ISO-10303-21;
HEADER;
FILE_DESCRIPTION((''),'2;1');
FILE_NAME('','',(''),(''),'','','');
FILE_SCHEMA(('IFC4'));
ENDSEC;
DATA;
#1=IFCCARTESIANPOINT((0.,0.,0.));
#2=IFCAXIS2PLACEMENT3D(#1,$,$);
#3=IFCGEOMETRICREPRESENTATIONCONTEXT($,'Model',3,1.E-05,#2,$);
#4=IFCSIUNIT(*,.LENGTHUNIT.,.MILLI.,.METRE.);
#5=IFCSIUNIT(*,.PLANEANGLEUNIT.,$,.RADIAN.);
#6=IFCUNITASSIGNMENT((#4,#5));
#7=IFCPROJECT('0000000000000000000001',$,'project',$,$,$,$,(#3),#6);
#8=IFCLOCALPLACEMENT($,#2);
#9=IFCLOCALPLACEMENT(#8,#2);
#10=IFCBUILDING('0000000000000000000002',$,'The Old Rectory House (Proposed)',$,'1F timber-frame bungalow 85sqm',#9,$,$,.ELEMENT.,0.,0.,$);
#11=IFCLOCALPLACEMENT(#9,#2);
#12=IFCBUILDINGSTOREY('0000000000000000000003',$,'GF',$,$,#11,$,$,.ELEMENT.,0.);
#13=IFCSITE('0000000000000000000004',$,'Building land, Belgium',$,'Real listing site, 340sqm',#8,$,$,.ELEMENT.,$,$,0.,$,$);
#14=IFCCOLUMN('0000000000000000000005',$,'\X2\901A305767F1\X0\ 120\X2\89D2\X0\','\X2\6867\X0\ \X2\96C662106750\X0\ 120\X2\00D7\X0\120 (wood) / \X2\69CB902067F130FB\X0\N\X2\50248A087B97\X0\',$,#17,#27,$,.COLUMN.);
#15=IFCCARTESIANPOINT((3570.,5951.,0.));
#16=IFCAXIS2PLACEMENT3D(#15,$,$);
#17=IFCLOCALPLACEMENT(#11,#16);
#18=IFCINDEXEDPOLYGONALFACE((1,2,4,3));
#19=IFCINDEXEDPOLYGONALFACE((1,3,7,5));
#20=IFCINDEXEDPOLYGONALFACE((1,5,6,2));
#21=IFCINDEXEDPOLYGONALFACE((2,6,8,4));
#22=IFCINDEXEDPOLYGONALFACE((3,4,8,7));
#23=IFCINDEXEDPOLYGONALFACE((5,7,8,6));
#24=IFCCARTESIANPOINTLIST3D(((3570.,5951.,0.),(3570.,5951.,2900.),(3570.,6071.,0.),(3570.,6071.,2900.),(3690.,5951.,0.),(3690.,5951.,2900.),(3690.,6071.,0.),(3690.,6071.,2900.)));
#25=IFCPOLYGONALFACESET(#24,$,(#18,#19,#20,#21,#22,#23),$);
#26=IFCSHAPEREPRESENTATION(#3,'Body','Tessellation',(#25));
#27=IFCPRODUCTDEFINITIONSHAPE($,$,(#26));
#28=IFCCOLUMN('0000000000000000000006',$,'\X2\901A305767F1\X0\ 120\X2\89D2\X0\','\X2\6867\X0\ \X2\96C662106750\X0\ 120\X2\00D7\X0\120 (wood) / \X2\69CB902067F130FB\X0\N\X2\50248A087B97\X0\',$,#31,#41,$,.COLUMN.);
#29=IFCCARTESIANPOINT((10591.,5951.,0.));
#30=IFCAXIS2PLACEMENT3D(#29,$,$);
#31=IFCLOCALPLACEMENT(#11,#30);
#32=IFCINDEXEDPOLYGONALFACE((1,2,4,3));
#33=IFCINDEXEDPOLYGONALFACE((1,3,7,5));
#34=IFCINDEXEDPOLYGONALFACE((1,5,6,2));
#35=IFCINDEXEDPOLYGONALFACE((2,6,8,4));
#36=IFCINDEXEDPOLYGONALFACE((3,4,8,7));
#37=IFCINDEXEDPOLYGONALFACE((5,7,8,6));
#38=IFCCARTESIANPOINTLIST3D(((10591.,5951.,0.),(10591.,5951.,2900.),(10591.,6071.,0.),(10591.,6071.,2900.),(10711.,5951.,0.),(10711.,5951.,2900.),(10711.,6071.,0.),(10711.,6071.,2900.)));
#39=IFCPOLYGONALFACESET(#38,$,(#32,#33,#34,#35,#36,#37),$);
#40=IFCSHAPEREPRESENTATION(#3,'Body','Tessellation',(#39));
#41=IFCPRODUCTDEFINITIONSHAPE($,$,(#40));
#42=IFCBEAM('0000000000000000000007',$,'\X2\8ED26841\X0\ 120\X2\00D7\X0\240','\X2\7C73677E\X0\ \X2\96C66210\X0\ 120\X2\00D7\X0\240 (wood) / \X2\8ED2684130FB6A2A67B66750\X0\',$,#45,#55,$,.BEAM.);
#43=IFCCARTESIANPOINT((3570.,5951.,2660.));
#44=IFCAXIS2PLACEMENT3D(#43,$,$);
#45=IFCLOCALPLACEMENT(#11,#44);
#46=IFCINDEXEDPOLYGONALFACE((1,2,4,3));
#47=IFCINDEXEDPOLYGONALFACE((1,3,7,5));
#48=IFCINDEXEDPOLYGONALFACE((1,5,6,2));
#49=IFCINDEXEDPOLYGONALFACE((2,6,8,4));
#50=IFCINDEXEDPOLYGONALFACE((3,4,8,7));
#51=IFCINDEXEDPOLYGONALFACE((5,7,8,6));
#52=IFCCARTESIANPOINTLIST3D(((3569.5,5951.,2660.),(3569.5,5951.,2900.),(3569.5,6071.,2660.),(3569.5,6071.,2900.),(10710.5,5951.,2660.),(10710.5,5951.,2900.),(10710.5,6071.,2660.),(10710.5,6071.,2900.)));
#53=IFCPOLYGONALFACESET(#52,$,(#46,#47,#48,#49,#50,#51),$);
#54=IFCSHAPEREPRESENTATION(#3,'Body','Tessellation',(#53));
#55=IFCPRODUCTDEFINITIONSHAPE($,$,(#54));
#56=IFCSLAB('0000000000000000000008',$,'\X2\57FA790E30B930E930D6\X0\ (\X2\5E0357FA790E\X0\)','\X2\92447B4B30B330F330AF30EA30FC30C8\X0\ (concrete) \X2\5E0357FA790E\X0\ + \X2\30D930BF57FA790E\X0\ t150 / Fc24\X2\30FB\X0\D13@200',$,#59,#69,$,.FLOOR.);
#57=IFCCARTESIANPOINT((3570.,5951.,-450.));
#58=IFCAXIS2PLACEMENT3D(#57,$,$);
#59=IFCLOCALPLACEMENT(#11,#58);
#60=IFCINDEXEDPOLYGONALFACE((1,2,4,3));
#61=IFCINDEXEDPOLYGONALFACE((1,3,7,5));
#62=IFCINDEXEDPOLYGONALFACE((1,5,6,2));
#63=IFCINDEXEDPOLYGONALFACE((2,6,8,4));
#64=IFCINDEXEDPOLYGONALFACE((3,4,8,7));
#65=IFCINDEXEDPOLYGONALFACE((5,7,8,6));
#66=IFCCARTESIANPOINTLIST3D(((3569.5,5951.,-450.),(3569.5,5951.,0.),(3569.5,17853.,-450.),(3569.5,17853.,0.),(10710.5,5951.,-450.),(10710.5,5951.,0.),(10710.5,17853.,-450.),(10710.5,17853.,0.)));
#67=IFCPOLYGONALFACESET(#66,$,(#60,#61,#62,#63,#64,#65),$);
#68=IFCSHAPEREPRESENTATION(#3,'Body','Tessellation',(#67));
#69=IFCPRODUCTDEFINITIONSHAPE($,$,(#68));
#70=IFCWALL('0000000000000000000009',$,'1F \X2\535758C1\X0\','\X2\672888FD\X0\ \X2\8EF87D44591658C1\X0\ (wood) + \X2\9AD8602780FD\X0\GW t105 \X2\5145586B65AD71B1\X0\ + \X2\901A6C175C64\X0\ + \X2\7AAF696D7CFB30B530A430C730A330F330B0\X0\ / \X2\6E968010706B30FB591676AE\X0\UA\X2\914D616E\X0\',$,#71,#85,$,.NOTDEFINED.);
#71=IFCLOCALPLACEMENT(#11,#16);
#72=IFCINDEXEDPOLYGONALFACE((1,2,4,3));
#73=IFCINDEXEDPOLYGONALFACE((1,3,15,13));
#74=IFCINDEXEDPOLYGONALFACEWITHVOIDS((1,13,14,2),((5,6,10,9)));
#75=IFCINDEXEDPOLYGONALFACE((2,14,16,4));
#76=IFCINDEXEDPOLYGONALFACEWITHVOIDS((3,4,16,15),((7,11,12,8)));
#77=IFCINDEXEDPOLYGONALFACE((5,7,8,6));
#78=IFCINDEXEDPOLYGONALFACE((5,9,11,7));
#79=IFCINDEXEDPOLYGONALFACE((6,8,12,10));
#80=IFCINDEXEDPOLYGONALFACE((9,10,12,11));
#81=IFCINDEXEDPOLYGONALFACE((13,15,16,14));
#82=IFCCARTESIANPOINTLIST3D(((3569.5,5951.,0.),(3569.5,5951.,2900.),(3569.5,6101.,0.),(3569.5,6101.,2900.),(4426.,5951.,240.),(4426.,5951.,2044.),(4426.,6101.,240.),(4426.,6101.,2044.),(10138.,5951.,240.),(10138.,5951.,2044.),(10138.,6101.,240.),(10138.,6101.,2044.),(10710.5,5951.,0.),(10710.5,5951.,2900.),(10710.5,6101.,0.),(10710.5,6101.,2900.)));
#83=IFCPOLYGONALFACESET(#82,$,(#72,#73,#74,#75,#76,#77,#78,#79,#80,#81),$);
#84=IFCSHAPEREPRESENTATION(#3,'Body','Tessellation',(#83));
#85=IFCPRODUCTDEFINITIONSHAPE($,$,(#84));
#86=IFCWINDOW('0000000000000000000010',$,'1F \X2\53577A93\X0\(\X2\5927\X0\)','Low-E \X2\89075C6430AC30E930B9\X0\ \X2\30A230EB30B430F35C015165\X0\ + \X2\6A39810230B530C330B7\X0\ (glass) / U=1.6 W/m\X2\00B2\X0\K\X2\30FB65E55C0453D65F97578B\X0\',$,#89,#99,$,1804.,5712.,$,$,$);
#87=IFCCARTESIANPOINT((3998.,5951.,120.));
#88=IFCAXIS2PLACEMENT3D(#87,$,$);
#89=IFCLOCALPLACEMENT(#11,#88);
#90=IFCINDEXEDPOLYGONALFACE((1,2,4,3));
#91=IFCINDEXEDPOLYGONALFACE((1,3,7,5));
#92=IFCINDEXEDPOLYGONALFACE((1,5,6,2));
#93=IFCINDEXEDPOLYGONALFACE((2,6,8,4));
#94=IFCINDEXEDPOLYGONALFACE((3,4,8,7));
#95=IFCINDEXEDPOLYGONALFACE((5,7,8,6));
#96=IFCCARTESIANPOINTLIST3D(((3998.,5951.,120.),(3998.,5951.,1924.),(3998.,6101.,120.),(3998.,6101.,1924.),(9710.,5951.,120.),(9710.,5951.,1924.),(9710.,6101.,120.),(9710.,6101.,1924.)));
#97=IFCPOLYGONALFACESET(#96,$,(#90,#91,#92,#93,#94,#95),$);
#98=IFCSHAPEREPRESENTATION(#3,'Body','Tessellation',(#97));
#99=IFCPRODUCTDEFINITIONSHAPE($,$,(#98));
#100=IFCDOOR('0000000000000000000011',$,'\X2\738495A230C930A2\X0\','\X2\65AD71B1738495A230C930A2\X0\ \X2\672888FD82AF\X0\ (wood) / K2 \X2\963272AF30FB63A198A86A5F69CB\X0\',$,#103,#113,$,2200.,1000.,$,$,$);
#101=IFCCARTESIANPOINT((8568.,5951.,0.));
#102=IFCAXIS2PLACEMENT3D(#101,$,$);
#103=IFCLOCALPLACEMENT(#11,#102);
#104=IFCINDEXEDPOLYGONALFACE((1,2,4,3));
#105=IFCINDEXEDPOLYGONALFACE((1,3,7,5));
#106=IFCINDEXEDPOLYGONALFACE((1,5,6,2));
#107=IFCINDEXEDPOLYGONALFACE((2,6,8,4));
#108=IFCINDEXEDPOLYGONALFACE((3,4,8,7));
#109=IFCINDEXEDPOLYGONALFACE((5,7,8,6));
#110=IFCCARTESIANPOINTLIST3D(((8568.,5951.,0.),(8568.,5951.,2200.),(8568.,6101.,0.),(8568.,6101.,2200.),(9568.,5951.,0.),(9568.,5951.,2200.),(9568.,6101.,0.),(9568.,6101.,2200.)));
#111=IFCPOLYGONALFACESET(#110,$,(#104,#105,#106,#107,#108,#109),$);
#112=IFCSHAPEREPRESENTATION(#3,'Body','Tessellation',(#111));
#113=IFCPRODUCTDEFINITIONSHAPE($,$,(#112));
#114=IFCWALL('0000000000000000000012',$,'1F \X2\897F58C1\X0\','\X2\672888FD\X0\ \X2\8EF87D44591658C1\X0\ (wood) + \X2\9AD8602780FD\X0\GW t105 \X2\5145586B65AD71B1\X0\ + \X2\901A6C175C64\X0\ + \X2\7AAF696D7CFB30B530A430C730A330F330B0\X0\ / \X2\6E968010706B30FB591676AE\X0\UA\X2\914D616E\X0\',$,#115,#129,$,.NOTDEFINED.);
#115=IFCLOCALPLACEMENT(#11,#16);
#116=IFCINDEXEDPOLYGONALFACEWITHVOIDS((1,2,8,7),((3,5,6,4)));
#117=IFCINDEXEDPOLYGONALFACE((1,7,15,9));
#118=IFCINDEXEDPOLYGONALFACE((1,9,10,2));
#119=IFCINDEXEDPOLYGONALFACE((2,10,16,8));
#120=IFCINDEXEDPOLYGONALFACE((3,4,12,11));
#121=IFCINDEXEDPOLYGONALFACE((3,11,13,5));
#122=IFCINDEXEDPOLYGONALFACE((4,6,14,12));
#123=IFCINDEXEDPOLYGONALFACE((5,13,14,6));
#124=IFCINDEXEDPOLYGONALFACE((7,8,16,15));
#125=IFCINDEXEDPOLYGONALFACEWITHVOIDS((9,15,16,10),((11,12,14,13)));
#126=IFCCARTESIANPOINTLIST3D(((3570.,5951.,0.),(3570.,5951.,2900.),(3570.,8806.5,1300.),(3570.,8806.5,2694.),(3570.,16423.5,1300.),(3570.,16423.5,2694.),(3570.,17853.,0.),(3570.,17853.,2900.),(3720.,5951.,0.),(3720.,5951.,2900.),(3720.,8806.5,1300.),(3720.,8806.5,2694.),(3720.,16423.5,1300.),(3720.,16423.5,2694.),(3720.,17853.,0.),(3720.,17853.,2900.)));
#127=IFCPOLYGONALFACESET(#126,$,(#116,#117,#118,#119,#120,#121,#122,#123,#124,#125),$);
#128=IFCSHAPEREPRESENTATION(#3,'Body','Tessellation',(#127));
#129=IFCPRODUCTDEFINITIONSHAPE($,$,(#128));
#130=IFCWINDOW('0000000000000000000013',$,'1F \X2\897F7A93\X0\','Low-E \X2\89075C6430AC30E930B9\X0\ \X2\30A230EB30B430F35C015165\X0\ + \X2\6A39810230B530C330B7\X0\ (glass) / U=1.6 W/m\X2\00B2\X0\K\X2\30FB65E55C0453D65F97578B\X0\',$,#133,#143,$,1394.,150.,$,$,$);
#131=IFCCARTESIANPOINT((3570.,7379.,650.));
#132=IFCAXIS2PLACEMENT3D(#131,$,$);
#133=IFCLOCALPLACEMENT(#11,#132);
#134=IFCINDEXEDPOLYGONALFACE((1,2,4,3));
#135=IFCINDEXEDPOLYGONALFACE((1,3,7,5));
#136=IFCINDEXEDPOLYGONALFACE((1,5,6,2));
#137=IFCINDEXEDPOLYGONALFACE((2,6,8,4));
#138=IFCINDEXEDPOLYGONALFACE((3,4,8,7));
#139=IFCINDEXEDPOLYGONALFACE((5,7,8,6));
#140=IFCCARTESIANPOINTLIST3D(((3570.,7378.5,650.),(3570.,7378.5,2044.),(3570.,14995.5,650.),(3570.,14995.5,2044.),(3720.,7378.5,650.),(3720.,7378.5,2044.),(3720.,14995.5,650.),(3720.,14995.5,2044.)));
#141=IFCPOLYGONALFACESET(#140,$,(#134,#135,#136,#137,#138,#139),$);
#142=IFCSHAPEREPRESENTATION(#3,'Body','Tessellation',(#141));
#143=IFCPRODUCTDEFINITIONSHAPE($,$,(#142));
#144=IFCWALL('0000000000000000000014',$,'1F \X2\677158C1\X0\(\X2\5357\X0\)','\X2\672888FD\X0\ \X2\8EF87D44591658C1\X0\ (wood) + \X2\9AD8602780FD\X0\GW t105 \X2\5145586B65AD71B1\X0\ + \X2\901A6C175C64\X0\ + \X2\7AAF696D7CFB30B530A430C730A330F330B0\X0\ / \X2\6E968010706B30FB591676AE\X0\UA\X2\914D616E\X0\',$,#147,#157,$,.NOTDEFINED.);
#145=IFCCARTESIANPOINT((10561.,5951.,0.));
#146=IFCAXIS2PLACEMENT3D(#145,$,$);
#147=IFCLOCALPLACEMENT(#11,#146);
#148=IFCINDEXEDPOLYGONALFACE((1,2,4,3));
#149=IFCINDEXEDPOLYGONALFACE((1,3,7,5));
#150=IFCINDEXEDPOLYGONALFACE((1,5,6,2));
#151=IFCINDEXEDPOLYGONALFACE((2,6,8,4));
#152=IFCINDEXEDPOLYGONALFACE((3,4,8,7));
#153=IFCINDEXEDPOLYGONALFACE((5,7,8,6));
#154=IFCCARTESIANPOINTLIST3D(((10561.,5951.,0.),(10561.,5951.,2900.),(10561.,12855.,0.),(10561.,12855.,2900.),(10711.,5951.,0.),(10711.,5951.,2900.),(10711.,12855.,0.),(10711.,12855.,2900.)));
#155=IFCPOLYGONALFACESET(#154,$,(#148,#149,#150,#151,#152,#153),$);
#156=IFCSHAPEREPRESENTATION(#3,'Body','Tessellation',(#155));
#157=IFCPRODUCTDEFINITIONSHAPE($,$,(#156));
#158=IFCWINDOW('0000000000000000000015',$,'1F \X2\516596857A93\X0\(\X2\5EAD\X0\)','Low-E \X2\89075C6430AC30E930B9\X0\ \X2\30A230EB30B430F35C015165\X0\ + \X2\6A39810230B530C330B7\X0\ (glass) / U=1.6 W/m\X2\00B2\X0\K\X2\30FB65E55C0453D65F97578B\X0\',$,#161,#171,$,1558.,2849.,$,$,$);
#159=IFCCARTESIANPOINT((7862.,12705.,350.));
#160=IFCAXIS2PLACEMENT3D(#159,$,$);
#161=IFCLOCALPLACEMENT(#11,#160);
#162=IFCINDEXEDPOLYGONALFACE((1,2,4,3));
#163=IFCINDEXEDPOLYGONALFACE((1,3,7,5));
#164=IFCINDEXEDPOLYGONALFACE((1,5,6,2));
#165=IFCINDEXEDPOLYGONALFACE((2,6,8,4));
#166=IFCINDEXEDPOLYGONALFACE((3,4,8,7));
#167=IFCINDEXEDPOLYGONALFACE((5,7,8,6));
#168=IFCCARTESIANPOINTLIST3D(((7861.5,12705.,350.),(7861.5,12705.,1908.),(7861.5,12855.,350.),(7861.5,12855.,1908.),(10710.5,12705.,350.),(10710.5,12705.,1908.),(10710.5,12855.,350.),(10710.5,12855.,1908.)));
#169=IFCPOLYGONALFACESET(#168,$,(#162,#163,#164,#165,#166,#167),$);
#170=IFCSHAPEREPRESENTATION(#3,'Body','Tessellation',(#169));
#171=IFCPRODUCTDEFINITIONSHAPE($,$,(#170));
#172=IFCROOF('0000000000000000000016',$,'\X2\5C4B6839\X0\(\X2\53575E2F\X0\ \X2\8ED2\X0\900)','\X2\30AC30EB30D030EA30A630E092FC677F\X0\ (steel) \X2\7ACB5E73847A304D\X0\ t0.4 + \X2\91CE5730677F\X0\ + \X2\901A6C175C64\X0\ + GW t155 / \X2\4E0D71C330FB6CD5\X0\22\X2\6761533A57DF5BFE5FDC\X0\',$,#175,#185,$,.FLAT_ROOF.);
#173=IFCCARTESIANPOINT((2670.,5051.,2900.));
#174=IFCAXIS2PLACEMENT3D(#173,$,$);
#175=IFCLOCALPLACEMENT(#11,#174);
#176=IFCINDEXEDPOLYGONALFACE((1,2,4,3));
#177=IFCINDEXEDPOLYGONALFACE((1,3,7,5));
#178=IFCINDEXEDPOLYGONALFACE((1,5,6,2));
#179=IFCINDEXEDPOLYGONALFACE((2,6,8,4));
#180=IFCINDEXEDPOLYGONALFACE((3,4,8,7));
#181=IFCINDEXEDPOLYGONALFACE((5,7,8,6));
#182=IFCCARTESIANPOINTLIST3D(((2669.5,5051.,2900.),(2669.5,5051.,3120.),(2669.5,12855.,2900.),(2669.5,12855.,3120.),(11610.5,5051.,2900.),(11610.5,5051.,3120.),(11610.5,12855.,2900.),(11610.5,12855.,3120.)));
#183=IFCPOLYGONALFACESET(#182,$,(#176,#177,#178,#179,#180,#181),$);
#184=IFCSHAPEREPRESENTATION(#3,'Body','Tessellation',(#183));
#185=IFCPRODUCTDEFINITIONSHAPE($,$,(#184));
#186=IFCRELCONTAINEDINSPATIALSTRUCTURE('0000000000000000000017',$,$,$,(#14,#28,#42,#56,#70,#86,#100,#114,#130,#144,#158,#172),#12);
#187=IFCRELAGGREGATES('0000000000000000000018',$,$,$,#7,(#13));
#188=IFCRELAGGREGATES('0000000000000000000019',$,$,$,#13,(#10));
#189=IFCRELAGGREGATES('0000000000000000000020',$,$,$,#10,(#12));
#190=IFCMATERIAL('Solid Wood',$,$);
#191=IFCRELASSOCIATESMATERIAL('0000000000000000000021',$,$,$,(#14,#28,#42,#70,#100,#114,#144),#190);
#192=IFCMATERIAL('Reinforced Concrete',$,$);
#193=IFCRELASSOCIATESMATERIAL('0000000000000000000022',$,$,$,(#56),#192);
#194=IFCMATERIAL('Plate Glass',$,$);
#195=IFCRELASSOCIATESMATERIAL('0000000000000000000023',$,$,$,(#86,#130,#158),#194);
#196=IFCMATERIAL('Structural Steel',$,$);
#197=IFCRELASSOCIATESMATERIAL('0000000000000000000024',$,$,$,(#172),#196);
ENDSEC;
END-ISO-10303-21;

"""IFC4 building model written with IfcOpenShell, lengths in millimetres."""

from ifc_helpers import new_model, si_unit, frame, frame_2d, origin, place, context, project, spatial, rectangle, extrude, material, element, fill, save


model = new_model("IFC4")

# Units and contexts
model_context = context("Model", 3, precision=1e-05, world=origin())
ifc_project = project(units=[si_unit("LENGTHUNIT", "METRE", prefix="MILLI"), si_unit("PLANEANGLEUNIT", "RADIAN")], contexts=[model_context])

# Site, building, storey
site_placement = place(None, origin())
site = spatial("IfcSite", under=ifc_project, at=site_placement, Name="Building land, Belgium", ObjectType="Real listing site, 340sqm", CompositionType="ELEMENT", RefElevation=0.0)
building_placement = place(site_placement, origin())
building = spatial("IfcBuilding", under=site, at=building_placement, Name="The Old Rectory House (Proposed)", ObjectType="1F timber-frame bungalow 85sqm", CompositionType="ELEMENT", ElevationOfRefHeight=0.0, ElevationOfTerrain=0.0)
storey_placement = place(building_placement, origin())
storey = spatial("IfcBuildingStorey", under=building, at=storey_placement, Name="GF", CompositionType="ELEMENT", Elevation=0.0)

# Columns
ifc_material_1 = material(Name="Solid Wood")
column_1_placement = place(storey_placement, frame((3570.0, 5951.0, 0.0)))
element("IfcColumn", 1, at=column_1_placement, inside=storey, material=ifc_material_1, Name="通し柱 120角", Description="桧 集成材 120×120 (wood) / 構造柱・N値計算", PredefinedType="COLUMN", context=model_context, shape_type="SweptSolid", body=[
    extrude(rectangle(XDim=120.0, YDim=120.0, at=frame_2d((60.0, 60.0))), frame((3570.0, 5951.0, 0.0)), (0.0, 0.0, 1.0), 2900.0),
])
column_2_placement = place(storey_placement, frame((10591.0, 5951.0, 0.0)))
element("IfcColumn", 2, at=column_2_placement, inside=storey, material=ifc_material_1, Name="通し柱 120角", Description="桧 集成材 120×120 (wood) / 構造柱・N値計算", PredefinedType="COLUMN", context=model_context, shape_type="SweptSolid", body=[
    extrude(rectangle(XDim=120.0, YDim=120.0, at=frame_2d((60.0, 60.0))), frame((10591.0, 5951.0, 0.0)), (0.0, 0.0, 1.0), 2900.0),
])

# Beam
beam_1_placement = place(storey_placement, frame((3570.0, 5951.0, 2660.0)))
element("IfcBeam", 3, at=beam_1_placement, inside=storey, material=ifc_material_1, Name="軒桁 120×240", Description="米松 集成 120×240 (wood) / 軒桁・横架材", PredefinedType="BEAM", context=model_context, shape_type="SweptSolid", body=[
    extrude(rectangle(XDim=7141.0, YDim=120.0, at=frame_2d((3570.0, 60.0))), frame((3570.0, 5951.0, 2660.0)), (0.0, 0.0, 1.0), 240.0),
])

# Slab
ifc_material_2 = material(Name="Reinforced Concrete")
slab_1_placement = place(storey_placement, frame((3570.0, 5951.0, -450.0)))
element("IfcSlab", 4, at=slab_1_placement, inside=storey, material=ifc_material_2, Name="基礎スラブ (布基礎)", Description="鉄筋コンクリート (concrete) 布基礎 + ベタ基礎 t150 / Fc24・D13@200", PredefinedType="FLOOR", context=model_context, shape_type="SweptSolid", body=[
    extrude(rectangle(XDim=7141.0, YDim=11902.0, at=frame_2d((3570.0, 5951.0))), frame((3570.0, 5951.0, -450.0)), (0.0, 0.0, 1.0), 450.0),
])

# Wall, openings, window, door
wall_1_placement = place(storey_placement, frame((3570.0, 5951.0, 0.0)))
wall_1 = element("IfcWall", 5, at=wall_1_placement, inside=storey, material=ifc_material_1, Name="1F 南壁", Description="木製 軸組外壁 (wood) + 高性能GW t105 充填断熱 + 通気層 + 窯業系サイディング / 準耐火・外皮UA配慮", PredefinedType="NOTDEFINED", context=model_context, shape_type="SweptSolid", body=[
    extrude(rectangle(XDim=7141.0, YDim=150.0, at=frame_2d((3570.0, 75.0))), frame((3570.0, 5951.0, 0.0)), (0.0, 0.0, 1.0), 2900.0),
])
opening_1_placement = place(storey_placement, frame((3998.0, 5951.0, 120.0)))
opening_1 = element("IfcOpeningElement", 6, at=opening_1_placement, cuts=wall_1, PredefinedType="NOTDEFINED", context=model_context, shape_type="SweptSolid", body=[
    extrude(rectangle(XDim=5712.0, YDim=150.0, at=frame_2d((2856.0, 75.0))), frame((3998.0, 5951.0, 120.0)), (0.0, 0.0, 1.0), 1804.0),
])
opening_2_placement = place(storey_placement, frame((8568.0, 5951.0, 0.0)))
opening_2 = element("IfcOpeningElement", 7, at=opening_2_placement, cuts=wall_1, PredefinedType="NOTDEFINED", context=model_context, shape_type="SweptSolid", body=[
    extrude(rectangle(XDim=1000.0, YDim=150.0, at=frame_2d((500.0, 75.0))), frame((8568.0, 5951.0, 0.0)), (0.0, 0.0, 1.0), 2200.0),
])
ifc_material_3 = material(Name="Plate Glass")
window_1_placement = place(storey_placement, frame((3998.0, 5951.0, 120.0)))
window_1 = element("IfcWindow", 8, at=window_1_placement, inside=storey, material=ifc_material_3, Name="1F 南窓(大)", Description="Low-E 複層ガラス アルゴン封入 + 樹脂サッシ (glass) / U=1.6 W/m²K・日射取得型", OverallHeight=1804.0, OverallWidth=5712.0, context=model_context, shape_type="SweptSolid", body=[
    extrude(rectangle(XDim=5712.0, YDim=150.0, at=frame_2d((2856.0, 75.0))), frame((3998.0, 5951.0, 120.0)), (0.0, 0.0, 1.0), 1804.0),
])
fill(opening_1, window_1)
door_1_placement = place(storey_placement, frame((8568.0, 5951.0, 0.0)))
door_1 = element("IfcDoor", 9, at=door_1_placement, inside=storey, material=ifc_material_1, Name="玄関ドア", Description="断熱玄関ドア 木製芯 (wood) / K2 防犯・採風機構", OverallHeight=2200.0, OverallWidth=1000.0, context=model_context, shape_type="SweptSolid", body=[
    extrude(rectangle(XDim=1000.0, YDim=150.0, at=frame_2d((500.0, 75.0))), frame((8568.0, 5951.0, 0.0)), (0.0, 0.0, 1.0), 2200.0),
])
fill(opening_2, door_1)

# Walls, openings, windows
wall_2_placement = place(storey_placement, frame((3570.0, 5951.0, 0.0)))
wall_2 = element("IfcWall", 10, at=wall_2_placement, inside=storey, material=ifc_material_1, Name="1F 西壁", Description="木製 軸組外壁 (wood) + 高性能GW t105 充填断熱 + 通気層 + 窯業系サイディング / 準耐火・外皮UA配慮", PredefinedType="NOTDEFINED", context=model_context, shape_type="SweptSolid", body=[
    extrude(rectangle(XDim=150.0, YDim=11902.0, at=frame_2d((75.0, 5951.0))), frame((3570.0, 5951.0, 0.0)), (0.0, 0.0, 1.0), 2900.0),
])
opening_3_placement = place(storey_placement, frame((3570.0, 7379.0, 650.0)))
opening_3 = element("IfcOpeningElement", 11, at=opening_3_placement, cuts=wall_2, PredefinedType="NOTDEFINED", context=model_context, shape_type="SweptSolid", body=[
    extrude(rectangle(XDim=150.0, YDim=7617.0, at=frame_2d((75.0, 3808.0))), frame((3570.0, 7379.0, 650.0)), (0.0, 0.0, 1.0), 1394.0),
])
window_2_placement = place(storey_placement, frame((3570.0, 7379.0, 650.0)))
window_2 = element("IfcWindow", 12, at=window_2_placement, inside=storey, material=ifc_material_3, Name="1F 西窓", Description="Low-E 複層ガラス アルゴン封入 + 樹脂サッシ (glass) / U=1.6 W/m²K・日射取得型", OverallHeight=1394.0, OverallWidth=150.0, context=model_context, shape_type="SweptSolid", body=[
    extrude(rectangle(XDim=150.0, YDim=7617.0, at=frame_2d((75.0, 3808.0))), frame((3570.0, 7379.0, 650.0)), (0.0, 0.0, 1.0), 1394.0),
])
fill(opening_3, window_2)
wall_3_placement = place(storey_placement, frame((10561.0, 5951.0, 0.0)))
wall_3 = element("IfcWall", 13, at=wall_3_placement, inside=storey, material=ifc_material_1, Name="1F 東壁(南)", Description="木製 軸組外壁 (wood) + 高性能GW t105 充填断熱 + 通気層 + 窯業系サイディング / 準耐火・外皮UA配慮", PredefinedType="NOTDEFINED", context=model_context, shape_type="SweptSolid", body=[
    extrude(rectangle(XDim=150.0, YDim=6904.0, at=frame_2d((75.0, 3452.0))), frame((10561.0, 5951.0, 0.0)), (0.0, 0.0, 1.0), 2900.0),
])
opening_4_placement = place(storey_placement, frame((7862.0, 12705.0, 350.0)))
opening_4 = element("IfcOpeningElement", 14, at=opening_4_placement, cuts=wall_3, PredefinedType="NOTDEFINED", context=model_context, shape_type="SweptSolid", body=[
    extrude(rectangle(XDim=2849.0, YDim=150.0, at=frame_2d((1424.0, 75.0))), frame((7862.0, 12705.0, 350.0)), (0.0, 0.0, 1.0), 1558.0),
])
window_3_placement = place(storey_placement, frame((7862.0, 12705.0, 350.0)))
window_3 = element("IfcWindow", 15, at=window_3_placement, inside=storey, material=ifc_material_3, Name="1F 入隅窓(庭)", Description="Low-E 複層ガラス アルゴン封入 + 樹脂サッシ (glass) / U=1.6 W/m²K・日射取得型", OverallHeight=1558.0, OverallWidth=2849.0, context=model_context, shape_type="SweptSolid", body=[
    extrude(rectangle(XDim=2849.0, YDim=150.0, at=frame_2d((1424.0, 75.0))), frame((7862.0, 12705.0, 350.0)), (0.0, 0.0, 1.0), 1558.0),
])
fill(opening_4, window_3)

# Roof
ifc_material_4 = material(Name="Structural Steel")
roof_placement = place(storey_placement, frame((2670.0, 5051.0, 2900.0)))
element("IfcRoof", 16, at=roof_placement, inside=storey, material=ifc_material_4, Name="屋根(南帯 軒900)", Description="ガルバリウム鋼板 (steel) 立平葺き t0.4 + 野地板 + 通気層 + GW t155 / 不燃・法22条区域対応", PredefinedType="FLAT_ROOF", context=model_context, shape_type="SweptSolid", body=[
    extrude(rectangle(XDim=8941.0, YDim=7804.0, at=frame_2d((4470.0, 3902.0))), frame((2670.0, 5051.0, 2900.0)), (0.0, 0.0, 1.0), 220.0),
])

save(model, "model.ifc")
